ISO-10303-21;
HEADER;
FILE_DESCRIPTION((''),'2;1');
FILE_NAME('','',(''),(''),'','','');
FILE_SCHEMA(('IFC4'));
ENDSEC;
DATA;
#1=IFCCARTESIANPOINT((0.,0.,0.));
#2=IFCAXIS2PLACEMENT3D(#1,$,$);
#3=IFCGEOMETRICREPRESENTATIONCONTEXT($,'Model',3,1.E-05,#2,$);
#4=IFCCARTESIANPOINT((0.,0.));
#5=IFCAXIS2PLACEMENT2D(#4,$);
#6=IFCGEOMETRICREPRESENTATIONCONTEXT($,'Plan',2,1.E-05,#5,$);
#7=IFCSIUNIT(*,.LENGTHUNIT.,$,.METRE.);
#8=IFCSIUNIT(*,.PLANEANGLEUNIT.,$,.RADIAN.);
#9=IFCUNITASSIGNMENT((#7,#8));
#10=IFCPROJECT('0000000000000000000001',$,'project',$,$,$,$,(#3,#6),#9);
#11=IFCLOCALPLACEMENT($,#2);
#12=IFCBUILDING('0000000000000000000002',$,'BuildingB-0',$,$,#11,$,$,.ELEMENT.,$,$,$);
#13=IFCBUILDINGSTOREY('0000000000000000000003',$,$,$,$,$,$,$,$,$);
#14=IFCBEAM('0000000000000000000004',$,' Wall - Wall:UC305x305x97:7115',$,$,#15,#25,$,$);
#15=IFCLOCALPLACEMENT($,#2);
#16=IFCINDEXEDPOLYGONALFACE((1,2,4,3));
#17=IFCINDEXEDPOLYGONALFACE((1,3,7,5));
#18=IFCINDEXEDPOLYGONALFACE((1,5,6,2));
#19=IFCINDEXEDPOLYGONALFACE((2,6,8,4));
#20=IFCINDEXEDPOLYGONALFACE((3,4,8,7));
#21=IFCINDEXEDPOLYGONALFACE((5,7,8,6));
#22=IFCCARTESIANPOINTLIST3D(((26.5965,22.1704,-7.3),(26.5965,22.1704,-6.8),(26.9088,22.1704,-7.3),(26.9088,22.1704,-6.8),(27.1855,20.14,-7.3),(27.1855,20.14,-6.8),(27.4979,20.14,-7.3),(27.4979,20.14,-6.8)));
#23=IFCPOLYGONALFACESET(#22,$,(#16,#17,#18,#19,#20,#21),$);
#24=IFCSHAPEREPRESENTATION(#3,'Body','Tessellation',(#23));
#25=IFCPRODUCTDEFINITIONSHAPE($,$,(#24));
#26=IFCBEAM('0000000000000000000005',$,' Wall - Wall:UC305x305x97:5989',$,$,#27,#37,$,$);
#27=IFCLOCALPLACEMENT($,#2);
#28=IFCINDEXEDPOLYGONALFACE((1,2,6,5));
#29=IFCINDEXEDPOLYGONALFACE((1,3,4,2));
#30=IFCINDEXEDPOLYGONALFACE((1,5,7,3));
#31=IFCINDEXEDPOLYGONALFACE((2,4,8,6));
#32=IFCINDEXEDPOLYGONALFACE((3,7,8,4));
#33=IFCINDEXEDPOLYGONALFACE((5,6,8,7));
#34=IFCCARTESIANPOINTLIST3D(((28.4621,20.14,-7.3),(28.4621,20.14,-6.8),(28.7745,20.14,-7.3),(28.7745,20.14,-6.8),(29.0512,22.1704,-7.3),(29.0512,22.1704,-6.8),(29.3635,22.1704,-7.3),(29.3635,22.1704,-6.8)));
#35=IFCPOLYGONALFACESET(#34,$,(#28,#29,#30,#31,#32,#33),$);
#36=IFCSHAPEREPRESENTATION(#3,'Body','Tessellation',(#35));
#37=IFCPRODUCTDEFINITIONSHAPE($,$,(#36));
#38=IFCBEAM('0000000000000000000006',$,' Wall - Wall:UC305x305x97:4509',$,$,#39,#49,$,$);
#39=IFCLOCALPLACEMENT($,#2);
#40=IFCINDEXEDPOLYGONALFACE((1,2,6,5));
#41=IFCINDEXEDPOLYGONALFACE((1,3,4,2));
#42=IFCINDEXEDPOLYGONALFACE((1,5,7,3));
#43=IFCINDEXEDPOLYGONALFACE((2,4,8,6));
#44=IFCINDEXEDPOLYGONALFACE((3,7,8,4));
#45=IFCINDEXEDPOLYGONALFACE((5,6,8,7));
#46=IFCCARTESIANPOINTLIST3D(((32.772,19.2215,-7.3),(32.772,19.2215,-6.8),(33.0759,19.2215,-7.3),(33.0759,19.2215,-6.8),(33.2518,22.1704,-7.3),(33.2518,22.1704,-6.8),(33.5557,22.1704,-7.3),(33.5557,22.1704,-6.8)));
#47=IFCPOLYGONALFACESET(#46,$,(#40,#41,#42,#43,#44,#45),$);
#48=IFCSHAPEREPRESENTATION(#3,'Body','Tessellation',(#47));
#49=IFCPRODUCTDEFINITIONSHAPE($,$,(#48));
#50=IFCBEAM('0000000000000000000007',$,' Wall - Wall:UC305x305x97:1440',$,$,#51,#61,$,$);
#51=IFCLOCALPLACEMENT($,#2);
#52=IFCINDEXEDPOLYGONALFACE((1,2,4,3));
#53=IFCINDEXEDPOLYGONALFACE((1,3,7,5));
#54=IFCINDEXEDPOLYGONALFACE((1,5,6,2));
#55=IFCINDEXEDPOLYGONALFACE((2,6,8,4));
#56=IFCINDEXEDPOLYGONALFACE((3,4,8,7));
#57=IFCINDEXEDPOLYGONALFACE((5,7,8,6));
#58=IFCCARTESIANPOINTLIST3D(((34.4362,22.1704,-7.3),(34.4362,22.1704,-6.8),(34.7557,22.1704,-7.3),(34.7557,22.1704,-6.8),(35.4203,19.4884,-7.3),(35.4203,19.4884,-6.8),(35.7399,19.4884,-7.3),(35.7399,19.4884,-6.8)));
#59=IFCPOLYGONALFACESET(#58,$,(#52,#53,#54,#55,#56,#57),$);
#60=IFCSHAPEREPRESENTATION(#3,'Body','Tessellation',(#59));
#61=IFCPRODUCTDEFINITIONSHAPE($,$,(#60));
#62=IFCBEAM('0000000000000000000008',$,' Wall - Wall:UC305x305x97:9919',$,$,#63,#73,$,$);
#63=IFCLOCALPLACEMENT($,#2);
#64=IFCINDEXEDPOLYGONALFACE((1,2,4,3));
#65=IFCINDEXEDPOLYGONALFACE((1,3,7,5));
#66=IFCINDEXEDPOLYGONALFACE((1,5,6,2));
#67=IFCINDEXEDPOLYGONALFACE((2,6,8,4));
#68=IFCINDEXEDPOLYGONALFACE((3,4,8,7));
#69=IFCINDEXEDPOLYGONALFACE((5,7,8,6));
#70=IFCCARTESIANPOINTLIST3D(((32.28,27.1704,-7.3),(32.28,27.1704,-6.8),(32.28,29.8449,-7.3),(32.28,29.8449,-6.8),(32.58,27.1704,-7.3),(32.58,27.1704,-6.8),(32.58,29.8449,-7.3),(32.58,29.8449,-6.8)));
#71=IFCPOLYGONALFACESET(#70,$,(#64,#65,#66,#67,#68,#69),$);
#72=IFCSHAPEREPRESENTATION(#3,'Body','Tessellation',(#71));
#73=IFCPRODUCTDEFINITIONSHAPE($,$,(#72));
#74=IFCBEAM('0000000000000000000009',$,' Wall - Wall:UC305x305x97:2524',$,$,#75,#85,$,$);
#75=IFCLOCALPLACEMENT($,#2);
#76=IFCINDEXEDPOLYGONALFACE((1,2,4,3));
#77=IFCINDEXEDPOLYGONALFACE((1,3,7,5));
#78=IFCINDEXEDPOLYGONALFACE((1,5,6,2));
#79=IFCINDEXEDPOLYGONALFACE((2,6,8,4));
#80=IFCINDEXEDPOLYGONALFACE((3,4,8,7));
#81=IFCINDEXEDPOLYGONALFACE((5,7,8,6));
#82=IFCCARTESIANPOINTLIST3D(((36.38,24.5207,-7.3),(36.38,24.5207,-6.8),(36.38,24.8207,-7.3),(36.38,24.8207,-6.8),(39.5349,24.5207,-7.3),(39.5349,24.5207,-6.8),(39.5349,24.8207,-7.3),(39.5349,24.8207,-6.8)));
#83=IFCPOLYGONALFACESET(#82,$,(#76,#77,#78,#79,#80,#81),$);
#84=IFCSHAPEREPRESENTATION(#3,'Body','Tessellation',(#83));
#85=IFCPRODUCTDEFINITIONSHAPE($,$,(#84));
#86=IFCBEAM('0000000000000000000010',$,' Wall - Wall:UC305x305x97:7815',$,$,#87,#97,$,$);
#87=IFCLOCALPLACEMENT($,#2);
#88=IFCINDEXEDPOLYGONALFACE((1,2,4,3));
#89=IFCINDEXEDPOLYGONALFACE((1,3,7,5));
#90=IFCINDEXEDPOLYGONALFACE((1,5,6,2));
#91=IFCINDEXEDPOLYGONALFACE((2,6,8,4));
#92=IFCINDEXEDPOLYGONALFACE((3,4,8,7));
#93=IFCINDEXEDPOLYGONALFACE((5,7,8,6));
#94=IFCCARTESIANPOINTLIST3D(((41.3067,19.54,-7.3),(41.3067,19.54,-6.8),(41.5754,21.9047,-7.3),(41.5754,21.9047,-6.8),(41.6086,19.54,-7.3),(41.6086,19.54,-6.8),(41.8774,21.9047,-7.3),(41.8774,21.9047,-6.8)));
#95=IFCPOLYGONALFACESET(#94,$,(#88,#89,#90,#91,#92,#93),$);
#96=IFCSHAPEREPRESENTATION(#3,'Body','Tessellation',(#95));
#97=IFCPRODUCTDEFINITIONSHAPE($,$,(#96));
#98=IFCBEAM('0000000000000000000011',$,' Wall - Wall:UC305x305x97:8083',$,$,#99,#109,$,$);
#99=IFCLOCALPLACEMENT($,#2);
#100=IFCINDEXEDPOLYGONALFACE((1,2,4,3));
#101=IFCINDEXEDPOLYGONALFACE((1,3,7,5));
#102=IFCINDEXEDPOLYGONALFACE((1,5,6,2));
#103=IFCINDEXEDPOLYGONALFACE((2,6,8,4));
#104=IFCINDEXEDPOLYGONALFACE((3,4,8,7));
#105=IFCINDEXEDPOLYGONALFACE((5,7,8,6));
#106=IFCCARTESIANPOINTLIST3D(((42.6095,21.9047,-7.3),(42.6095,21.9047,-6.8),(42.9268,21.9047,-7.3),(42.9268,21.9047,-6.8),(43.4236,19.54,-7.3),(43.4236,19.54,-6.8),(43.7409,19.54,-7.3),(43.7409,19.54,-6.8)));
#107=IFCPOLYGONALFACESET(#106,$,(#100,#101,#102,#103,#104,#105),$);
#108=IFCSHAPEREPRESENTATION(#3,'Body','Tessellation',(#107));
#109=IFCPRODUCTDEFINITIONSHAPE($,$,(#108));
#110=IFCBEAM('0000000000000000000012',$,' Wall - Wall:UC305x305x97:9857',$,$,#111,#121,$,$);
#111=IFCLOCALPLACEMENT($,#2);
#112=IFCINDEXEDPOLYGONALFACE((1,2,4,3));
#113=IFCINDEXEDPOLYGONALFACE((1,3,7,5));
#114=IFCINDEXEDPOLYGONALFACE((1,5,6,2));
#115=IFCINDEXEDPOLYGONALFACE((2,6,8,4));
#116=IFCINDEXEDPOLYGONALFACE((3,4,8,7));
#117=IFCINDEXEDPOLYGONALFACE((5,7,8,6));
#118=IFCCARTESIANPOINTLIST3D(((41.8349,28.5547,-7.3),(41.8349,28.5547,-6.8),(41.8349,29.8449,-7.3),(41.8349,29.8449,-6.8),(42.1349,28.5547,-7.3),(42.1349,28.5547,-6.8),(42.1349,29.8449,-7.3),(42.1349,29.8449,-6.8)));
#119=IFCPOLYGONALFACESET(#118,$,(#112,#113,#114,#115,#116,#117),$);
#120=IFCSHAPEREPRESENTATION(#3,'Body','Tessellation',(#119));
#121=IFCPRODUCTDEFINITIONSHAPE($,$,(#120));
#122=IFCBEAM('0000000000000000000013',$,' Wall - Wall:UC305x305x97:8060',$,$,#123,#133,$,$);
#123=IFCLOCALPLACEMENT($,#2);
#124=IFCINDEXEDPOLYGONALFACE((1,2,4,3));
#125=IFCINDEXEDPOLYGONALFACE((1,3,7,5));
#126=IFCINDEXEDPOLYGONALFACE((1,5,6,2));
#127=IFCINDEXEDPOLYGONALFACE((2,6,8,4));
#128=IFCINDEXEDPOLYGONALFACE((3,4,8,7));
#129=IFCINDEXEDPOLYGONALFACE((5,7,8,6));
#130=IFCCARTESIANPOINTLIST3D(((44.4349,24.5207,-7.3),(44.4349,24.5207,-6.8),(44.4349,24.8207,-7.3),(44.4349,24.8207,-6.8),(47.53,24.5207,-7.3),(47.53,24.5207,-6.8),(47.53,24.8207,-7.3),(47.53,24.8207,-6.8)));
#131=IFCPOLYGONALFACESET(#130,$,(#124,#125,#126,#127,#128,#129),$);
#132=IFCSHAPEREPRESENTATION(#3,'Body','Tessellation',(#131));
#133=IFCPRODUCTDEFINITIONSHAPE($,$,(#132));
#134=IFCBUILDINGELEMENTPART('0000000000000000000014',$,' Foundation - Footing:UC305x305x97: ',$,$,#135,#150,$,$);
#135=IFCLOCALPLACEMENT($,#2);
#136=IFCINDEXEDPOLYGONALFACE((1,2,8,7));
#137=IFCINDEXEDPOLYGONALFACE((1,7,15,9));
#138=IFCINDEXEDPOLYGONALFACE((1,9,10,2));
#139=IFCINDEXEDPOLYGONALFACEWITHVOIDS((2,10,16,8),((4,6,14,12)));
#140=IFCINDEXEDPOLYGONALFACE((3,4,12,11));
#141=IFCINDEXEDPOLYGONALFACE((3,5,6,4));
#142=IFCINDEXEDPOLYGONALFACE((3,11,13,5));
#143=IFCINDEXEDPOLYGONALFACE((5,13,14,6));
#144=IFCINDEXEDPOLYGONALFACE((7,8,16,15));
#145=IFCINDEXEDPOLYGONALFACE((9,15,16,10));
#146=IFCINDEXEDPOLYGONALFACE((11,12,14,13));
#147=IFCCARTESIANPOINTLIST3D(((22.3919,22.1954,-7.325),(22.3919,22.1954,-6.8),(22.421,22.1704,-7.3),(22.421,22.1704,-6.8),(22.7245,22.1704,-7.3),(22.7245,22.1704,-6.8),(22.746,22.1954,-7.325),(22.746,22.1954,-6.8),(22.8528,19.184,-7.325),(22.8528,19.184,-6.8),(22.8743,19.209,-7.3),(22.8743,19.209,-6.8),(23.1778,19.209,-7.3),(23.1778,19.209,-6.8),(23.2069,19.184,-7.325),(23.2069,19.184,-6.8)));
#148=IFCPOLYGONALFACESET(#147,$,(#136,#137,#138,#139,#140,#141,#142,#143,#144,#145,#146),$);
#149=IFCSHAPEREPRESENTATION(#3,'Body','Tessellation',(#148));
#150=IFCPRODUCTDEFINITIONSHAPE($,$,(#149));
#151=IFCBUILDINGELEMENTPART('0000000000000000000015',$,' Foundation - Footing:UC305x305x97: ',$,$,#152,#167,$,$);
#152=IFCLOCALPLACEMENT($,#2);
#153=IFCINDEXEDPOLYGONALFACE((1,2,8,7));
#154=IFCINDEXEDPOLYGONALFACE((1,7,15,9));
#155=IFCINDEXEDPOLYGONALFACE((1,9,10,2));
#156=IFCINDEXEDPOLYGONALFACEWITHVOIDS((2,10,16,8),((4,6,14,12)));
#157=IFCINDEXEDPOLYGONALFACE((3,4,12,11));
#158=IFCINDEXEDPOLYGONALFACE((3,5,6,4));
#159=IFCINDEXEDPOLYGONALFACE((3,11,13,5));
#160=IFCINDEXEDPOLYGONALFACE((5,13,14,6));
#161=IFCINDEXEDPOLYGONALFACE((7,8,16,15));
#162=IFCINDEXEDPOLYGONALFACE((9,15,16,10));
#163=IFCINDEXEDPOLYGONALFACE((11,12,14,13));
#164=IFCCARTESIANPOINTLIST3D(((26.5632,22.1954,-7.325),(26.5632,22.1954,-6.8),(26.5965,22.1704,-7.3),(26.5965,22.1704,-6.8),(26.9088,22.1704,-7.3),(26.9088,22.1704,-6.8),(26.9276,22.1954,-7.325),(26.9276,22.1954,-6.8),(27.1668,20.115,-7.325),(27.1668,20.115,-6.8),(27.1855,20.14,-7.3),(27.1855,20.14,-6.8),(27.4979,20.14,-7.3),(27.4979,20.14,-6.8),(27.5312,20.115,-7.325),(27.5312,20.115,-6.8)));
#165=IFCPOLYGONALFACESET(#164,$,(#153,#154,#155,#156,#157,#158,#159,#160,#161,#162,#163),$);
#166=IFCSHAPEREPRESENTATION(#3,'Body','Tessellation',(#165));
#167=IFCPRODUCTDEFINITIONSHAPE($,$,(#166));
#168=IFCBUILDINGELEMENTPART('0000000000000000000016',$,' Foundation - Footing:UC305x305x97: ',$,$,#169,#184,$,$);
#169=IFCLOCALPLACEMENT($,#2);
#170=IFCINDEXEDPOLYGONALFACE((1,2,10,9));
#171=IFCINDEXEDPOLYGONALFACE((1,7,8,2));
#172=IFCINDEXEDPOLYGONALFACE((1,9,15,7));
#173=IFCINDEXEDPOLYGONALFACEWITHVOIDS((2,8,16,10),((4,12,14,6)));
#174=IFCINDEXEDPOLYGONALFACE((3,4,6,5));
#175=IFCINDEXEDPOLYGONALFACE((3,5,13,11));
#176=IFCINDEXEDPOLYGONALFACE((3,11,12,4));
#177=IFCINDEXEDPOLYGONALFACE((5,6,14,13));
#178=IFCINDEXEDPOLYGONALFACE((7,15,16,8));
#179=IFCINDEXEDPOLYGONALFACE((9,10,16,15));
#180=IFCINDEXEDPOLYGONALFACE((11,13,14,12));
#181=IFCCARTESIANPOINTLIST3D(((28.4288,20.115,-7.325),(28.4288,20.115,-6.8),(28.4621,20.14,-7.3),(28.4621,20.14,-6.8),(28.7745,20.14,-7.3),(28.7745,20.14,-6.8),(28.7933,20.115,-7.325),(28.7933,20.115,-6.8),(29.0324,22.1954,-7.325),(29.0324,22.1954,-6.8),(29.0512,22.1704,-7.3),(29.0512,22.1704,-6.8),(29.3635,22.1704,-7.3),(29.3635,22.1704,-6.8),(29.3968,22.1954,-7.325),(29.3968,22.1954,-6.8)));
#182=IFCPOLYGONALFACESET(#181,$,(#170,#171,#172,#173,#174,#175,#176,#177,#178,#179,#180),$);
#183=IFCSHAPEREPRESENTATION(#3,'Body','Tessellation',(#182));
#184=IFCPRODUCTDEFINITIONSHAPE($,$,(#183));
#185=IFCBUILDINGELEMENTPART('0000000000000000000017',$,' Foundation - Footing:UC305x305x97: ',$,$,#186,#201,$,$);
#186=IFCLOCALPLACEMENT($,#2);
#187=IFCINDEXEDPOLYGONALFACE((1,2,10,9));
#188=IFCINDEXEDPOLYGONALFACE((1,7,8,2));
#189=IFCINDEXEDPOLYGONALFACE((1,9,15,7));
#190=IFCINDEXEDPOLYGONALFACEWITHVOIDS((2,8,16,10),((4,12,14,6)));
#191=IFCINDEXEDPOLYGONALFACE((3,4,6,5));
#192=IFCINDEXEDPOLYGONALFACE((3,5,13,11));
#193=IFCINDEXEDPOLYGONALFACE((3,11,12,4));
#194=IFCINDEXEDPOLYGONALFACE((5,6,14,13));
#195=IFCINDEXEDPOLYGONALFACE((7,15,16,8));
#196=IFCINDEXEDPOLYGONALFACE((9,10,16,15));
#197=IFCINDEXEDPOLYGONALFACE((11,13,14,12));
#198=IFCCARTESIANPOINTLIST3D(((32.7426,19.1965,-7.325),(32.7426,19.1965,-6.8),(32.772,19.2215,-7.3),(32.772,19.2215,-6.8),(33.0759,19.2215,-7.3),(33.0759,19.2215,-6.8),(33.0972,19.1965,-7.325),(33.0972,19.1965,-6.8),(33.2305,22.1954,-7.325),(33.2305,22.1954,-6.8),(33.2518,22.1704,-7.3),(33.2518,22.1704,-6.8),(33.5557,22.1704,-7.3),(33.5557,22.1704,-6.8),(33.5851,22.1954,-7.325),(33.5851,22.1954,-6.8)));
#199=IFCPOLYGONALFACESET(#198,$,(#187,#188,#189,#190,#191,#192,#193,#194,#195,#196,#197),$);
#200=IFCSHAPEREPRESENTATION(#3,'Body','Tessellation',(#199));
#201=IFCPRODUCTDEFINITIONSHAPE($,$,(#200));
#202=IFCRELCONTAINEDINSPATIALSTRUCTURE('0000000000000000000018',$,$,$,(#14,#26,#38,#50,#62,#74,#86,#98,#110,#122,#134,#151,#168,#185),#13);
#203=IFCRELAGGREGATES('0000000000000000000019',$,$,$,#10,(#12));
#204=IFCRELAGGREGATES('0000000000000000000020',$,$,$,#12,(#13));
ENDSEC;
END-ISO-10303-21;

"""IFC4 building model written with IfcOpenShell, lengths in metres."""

from ifc_helpers import new_model, si_unit, origin, origin_2d, place, context, project, spatial, polyline, outline, extrude, element, save


model = new_model("IFC4")

# Units and contexts
model_context = context("Model", 3, precision=1e-05, world=origin())
plan_context = context("Plan", 2, precision=1e-05, world=origin_2d())
ifc_project = project(units=[si_unit("LENGTHUNIT", "METRE"), si_unit("PLANEANGLEUNIT", "RADIAN")], contexts=[model_context, plan_context])

# Building, storey
building_placement = place(None, origin())
building = spatial("IfcBuilding", under=ifc_project, at=building_placement, Name="BuildingB-0", CompositionType="ELEMENT")
storey = spatial("IfcBuildingStorey", under=building)

# Beams
element("IfcBeam", 1, inside=storey, Name=" Wall - Wall:UC305x305x97:7115", context=model_context, shape_type="SweptSolid", body=[
    extrude(outline(polyline([(27.1855, 20.14, -7.3), (27.4979, 20.14, -7.3), (26.9088, 22.1704, -7.3), (26.5965, 22.1704, -7.3), (27.1855, 20.14, -7.3)])), None, (0.0, 0.0, 1.0), 0.5),
])
element("IfcBeam", 2, inside=storey, Name=" Wall - Wall:UC305x305x97:5989", context=model_context, shape_type="SweptSolid", body=[
    extrude(outline(polyline([(28.4621, 20.14, -7.3), (29.0512, 22.1704, -7.3), (29.3635, 22.1704, -7.3), (28.7745, 20.14, -7.3), (28.4621, 20.14, -7.3)])), None, (0.0, 0.0, 1.0), 0.5),
])
element("IfcBeam", 3, inside=storey, Name=" Wall - Wall:UC305x305x97:4509", context=model_context, shape_type="SweptSolid", body=[
    extrude(outline(polyline([(32.772, 19.2215, -7.3), (33.0759, 19.2215, -7.3), (33.5557, 22.1704, -7.3), (33.2518, 22.1704, -7.3), (32.772, 19.2215, -7.3)])), None, (0.0, 0.0, 1.0), 0.5),
])
element("IfcBeam", 4, inside=storey, Name=" Wall - Wall:UC305x305x97:1440", context=model_context, shape_type="SweptSolid", body=[
    extrude(outline(polyline([(35.4203, 19.4884, -7.3), (35.7399, 19.4884, -7.3), (34.7557, 22.1704, -7.3), (34.4362, 22.1704, -7.3), (35.4203, 19.4884, -7.3)])), None, (0.0, 0.0, 1.0), 0.5),
])
element("IfcBeam", 5, inside=storey, Name=" Wall - Wall:UC305x305x97:9919", context=model_context, shape_type="SweptSolid", body=[
    extrude(outline(polyline([(32.28, 27.1704, -7.3), (32.58, 27.1704, -7.3), (32.58, 29.8449, -7.3), (32.28, 29.8449, -7.3), (32.28, 27.1704, -7.3)])), None, (0.0, 0.0, 1.0), 0.5),
])
element("IfcBeam", 6, inside=storey, Name=" Wall - Wall:UC305x305x97:2524", context=model_context, shape_type="SweptSolid", body=[
    extrude(outline(polyline([(36.38, 24.5207, -7.3), (36.38, 24.8207, -7.3), (39.5349, 24.8207, -7.3), (39.5349, 24.5207, -7.3), (36.38, 24.5207, -7.3)])), None, (0.0, 0.0, 1.0), 0.5),
])
element("IfcBeam", 7, inside=storey, Name=" Wall - Wall:UC305x305x97:7815", context=model_context, shape_type="SweptSolid", body=[
    extrude(outline(polyline([(41.3067, 19.54, -7.3), (41.6086, 19.54, -7.3), (41.8774, 21.9047, -7.3), (41.5754, 21.9047, -7.3), (41.3067, 19.54, -7.3)])), None, (0.0, 0.0, 1.0), 0.5),
])
element("IfcBeam", 8, inside=storey, Name=" Wall - Wall:UC305x305x97:8083", context=model_context, shape_type="SweptSolid", body=[
    extrude(outline(polyline([(43.4236, 19.54, -7.3), (43.7409, 19.54, -7.3), (42.9268, 21.9047, -7.3), (42.6095, 21.9047, -7.3), (43.4236, 19.54, -7.3)])), None, (0.0, 0.0, 1.0), 0.5),
])
element("IfcBeam", 9, inside=storey, Name=" Wall - Wall:UC305x305x97:9857", context=model_context, shape_type="SweptSolid", body=[
    extrude(outline(polyline([(41.8349, 28.5547, -7.3), (42.1349, 28.5547, -7.3), (42.1349, 29.8449, -7.3), (41.8349, 29.8449, -7.3), (41.8349, 28.5547, -7.3)])), None, (0.0, 0.0, 1.0), 0.5),
])
element("IfcBeam", 10, inside=storey, Name=" Wall - Wall:UC305x305x97:8060", context=model_context, shape_type="SweptSolid", body=[
    extrude(outline(polyline([(44.4349, 24.5207, -7.3), (44.4349, 24.8207, -7.3), (47.53, 24.8207, -7.3), (47.53, 24.5207, -7.3), (44.4349, 24.5207, -7.3)])), None, (0.0, 0.0, 1.0), 0.5),
])

# Building element parts, openings
building_element_part_1 = element("IfcBuildingElementPart", 11, inside=storey, Name=" Foundation - Footing:UC305x305x97: ", context=model_context, shape_type="SweptSolid", body=[
    extrude(outline(polyline([(22.8528, 19.184, -7.325), (23.2069, 19.184, -7.325), (22.746, 22.1954, -7.325), (22.3919, 22.1954, -7.325), (22.8528, 19.184, -7.325)])), None, (0.0, 0.0, 1.0), 0.525),
])
element("IfcOpeningElement", 12, inside=storey, cuts=building_element_part_1, context=model_context, shape_type="SweptSolid", body=[
    extrude(outline(polyline([(22.8743, 19.209, -7.3), (23.1778, 19.209, -7.3), (22.7245, 22.1704, -7.3), (22.421, 22.1704, -7.3), (22.8743, 19.209, -7.3)])), None, (0.0, 0.0, 1.0), 0.5),
])
building_element_part_2 = element("IfcBuildingElementPart", 13, inside=storey, Name=" Foundation - Footing:UC305x305x97: ", context=model_context, shape_type="SweptSolid", body=[
    extrude(outline(polyline([(27.1668, 20.115, -7.325), (27.5312, 20.115, -7.325), (26.9276, 22.1954, -7.325), (26.5632, 22.1954, -7.325), (27.1668, 20.115, -7.325)])), None, (0.0, 0.0, 1.0), 0.525),
])
element("IfcOpeningElement", 14, inside=storey, cuts=building_element_part_2, context=model_context, shape_type="SweptSolid", body=[
    extrude(outline(polyline([(27.1855, 20.14, -7.3), (27.4979, 20.14, -7.3), (26.9088, 22.1704, -7.3), (26.5965, 22.1704, -7.3), (27.1855, 20.14, -7.3)])), None, (0.0, 0.0, 1.0), 0.5),
])
building_element_part_3 = element("IfcBuildingElementPart", 15, inside=storey, Name=" Foundation - Footing:UC305x305x97: ", context=model_context, shape_type="SweptSolid", body=[
    extrude(outline(polyline([(28.4288, 20.115, -7.325), (29.0324, 22.1954, -7.325), (29.3968, 22.1954, -7.325), (28.7933, 20.115, -7.325), (28.4288, 20.115, -7.325)])), None, (0.0, 0.0, 1.0), 0.525),
])
element("IfcOpeningElement", 16, inside=storey, cuts=building_element_part_3, context=model_context, shape_type="SweptSolid", body=[
    extrude(outline(polyline([(28.4621, 20.14, -7.3), (29.0512, 22.1704, -7.3), (29.3635, 22.1704, -7.3), (28.7745, 20.14, -7.3), (28.4621, 20.14, -7.3)])), None, (0.0, 0.0, 1.0), 0.5),
])
building_element_part_4 = element("IfcBuildingElementPart", 17, inside=storey, Name=" Foundation - Footing:UC305x305x97: ", context=model_context, shape_type="SweptSolid", body=[
    extrude(outline(polyline([(32.7426, 19.1965, -7.325), (33.0972, 19.1965, -7.325), (33.5851, 22.1954, -7.325), (33.2305, 22.1954, -7.325), (32.7426, 19.1965, -7.325)])), None, (0.0, 0.0, 1.0), 0.525),
])
element("IfcOpeningElement", 18, inside=storey, cuts=building_element_part_4, context=model_context, shape_type="SweptSolid", body=[
    extrude(outline(polyline([(32.772, 19.2215, -7.3), (33.0759, 19.2215, -7.3), (33.5557, 22.1704, -7.3), (33.2518, 22.1704, -7.3), (32.772, 19.2215, -7.3)])), None, (0.0, 0.0, 1.0), 0.5),
])

save(model, "model.ifc")
